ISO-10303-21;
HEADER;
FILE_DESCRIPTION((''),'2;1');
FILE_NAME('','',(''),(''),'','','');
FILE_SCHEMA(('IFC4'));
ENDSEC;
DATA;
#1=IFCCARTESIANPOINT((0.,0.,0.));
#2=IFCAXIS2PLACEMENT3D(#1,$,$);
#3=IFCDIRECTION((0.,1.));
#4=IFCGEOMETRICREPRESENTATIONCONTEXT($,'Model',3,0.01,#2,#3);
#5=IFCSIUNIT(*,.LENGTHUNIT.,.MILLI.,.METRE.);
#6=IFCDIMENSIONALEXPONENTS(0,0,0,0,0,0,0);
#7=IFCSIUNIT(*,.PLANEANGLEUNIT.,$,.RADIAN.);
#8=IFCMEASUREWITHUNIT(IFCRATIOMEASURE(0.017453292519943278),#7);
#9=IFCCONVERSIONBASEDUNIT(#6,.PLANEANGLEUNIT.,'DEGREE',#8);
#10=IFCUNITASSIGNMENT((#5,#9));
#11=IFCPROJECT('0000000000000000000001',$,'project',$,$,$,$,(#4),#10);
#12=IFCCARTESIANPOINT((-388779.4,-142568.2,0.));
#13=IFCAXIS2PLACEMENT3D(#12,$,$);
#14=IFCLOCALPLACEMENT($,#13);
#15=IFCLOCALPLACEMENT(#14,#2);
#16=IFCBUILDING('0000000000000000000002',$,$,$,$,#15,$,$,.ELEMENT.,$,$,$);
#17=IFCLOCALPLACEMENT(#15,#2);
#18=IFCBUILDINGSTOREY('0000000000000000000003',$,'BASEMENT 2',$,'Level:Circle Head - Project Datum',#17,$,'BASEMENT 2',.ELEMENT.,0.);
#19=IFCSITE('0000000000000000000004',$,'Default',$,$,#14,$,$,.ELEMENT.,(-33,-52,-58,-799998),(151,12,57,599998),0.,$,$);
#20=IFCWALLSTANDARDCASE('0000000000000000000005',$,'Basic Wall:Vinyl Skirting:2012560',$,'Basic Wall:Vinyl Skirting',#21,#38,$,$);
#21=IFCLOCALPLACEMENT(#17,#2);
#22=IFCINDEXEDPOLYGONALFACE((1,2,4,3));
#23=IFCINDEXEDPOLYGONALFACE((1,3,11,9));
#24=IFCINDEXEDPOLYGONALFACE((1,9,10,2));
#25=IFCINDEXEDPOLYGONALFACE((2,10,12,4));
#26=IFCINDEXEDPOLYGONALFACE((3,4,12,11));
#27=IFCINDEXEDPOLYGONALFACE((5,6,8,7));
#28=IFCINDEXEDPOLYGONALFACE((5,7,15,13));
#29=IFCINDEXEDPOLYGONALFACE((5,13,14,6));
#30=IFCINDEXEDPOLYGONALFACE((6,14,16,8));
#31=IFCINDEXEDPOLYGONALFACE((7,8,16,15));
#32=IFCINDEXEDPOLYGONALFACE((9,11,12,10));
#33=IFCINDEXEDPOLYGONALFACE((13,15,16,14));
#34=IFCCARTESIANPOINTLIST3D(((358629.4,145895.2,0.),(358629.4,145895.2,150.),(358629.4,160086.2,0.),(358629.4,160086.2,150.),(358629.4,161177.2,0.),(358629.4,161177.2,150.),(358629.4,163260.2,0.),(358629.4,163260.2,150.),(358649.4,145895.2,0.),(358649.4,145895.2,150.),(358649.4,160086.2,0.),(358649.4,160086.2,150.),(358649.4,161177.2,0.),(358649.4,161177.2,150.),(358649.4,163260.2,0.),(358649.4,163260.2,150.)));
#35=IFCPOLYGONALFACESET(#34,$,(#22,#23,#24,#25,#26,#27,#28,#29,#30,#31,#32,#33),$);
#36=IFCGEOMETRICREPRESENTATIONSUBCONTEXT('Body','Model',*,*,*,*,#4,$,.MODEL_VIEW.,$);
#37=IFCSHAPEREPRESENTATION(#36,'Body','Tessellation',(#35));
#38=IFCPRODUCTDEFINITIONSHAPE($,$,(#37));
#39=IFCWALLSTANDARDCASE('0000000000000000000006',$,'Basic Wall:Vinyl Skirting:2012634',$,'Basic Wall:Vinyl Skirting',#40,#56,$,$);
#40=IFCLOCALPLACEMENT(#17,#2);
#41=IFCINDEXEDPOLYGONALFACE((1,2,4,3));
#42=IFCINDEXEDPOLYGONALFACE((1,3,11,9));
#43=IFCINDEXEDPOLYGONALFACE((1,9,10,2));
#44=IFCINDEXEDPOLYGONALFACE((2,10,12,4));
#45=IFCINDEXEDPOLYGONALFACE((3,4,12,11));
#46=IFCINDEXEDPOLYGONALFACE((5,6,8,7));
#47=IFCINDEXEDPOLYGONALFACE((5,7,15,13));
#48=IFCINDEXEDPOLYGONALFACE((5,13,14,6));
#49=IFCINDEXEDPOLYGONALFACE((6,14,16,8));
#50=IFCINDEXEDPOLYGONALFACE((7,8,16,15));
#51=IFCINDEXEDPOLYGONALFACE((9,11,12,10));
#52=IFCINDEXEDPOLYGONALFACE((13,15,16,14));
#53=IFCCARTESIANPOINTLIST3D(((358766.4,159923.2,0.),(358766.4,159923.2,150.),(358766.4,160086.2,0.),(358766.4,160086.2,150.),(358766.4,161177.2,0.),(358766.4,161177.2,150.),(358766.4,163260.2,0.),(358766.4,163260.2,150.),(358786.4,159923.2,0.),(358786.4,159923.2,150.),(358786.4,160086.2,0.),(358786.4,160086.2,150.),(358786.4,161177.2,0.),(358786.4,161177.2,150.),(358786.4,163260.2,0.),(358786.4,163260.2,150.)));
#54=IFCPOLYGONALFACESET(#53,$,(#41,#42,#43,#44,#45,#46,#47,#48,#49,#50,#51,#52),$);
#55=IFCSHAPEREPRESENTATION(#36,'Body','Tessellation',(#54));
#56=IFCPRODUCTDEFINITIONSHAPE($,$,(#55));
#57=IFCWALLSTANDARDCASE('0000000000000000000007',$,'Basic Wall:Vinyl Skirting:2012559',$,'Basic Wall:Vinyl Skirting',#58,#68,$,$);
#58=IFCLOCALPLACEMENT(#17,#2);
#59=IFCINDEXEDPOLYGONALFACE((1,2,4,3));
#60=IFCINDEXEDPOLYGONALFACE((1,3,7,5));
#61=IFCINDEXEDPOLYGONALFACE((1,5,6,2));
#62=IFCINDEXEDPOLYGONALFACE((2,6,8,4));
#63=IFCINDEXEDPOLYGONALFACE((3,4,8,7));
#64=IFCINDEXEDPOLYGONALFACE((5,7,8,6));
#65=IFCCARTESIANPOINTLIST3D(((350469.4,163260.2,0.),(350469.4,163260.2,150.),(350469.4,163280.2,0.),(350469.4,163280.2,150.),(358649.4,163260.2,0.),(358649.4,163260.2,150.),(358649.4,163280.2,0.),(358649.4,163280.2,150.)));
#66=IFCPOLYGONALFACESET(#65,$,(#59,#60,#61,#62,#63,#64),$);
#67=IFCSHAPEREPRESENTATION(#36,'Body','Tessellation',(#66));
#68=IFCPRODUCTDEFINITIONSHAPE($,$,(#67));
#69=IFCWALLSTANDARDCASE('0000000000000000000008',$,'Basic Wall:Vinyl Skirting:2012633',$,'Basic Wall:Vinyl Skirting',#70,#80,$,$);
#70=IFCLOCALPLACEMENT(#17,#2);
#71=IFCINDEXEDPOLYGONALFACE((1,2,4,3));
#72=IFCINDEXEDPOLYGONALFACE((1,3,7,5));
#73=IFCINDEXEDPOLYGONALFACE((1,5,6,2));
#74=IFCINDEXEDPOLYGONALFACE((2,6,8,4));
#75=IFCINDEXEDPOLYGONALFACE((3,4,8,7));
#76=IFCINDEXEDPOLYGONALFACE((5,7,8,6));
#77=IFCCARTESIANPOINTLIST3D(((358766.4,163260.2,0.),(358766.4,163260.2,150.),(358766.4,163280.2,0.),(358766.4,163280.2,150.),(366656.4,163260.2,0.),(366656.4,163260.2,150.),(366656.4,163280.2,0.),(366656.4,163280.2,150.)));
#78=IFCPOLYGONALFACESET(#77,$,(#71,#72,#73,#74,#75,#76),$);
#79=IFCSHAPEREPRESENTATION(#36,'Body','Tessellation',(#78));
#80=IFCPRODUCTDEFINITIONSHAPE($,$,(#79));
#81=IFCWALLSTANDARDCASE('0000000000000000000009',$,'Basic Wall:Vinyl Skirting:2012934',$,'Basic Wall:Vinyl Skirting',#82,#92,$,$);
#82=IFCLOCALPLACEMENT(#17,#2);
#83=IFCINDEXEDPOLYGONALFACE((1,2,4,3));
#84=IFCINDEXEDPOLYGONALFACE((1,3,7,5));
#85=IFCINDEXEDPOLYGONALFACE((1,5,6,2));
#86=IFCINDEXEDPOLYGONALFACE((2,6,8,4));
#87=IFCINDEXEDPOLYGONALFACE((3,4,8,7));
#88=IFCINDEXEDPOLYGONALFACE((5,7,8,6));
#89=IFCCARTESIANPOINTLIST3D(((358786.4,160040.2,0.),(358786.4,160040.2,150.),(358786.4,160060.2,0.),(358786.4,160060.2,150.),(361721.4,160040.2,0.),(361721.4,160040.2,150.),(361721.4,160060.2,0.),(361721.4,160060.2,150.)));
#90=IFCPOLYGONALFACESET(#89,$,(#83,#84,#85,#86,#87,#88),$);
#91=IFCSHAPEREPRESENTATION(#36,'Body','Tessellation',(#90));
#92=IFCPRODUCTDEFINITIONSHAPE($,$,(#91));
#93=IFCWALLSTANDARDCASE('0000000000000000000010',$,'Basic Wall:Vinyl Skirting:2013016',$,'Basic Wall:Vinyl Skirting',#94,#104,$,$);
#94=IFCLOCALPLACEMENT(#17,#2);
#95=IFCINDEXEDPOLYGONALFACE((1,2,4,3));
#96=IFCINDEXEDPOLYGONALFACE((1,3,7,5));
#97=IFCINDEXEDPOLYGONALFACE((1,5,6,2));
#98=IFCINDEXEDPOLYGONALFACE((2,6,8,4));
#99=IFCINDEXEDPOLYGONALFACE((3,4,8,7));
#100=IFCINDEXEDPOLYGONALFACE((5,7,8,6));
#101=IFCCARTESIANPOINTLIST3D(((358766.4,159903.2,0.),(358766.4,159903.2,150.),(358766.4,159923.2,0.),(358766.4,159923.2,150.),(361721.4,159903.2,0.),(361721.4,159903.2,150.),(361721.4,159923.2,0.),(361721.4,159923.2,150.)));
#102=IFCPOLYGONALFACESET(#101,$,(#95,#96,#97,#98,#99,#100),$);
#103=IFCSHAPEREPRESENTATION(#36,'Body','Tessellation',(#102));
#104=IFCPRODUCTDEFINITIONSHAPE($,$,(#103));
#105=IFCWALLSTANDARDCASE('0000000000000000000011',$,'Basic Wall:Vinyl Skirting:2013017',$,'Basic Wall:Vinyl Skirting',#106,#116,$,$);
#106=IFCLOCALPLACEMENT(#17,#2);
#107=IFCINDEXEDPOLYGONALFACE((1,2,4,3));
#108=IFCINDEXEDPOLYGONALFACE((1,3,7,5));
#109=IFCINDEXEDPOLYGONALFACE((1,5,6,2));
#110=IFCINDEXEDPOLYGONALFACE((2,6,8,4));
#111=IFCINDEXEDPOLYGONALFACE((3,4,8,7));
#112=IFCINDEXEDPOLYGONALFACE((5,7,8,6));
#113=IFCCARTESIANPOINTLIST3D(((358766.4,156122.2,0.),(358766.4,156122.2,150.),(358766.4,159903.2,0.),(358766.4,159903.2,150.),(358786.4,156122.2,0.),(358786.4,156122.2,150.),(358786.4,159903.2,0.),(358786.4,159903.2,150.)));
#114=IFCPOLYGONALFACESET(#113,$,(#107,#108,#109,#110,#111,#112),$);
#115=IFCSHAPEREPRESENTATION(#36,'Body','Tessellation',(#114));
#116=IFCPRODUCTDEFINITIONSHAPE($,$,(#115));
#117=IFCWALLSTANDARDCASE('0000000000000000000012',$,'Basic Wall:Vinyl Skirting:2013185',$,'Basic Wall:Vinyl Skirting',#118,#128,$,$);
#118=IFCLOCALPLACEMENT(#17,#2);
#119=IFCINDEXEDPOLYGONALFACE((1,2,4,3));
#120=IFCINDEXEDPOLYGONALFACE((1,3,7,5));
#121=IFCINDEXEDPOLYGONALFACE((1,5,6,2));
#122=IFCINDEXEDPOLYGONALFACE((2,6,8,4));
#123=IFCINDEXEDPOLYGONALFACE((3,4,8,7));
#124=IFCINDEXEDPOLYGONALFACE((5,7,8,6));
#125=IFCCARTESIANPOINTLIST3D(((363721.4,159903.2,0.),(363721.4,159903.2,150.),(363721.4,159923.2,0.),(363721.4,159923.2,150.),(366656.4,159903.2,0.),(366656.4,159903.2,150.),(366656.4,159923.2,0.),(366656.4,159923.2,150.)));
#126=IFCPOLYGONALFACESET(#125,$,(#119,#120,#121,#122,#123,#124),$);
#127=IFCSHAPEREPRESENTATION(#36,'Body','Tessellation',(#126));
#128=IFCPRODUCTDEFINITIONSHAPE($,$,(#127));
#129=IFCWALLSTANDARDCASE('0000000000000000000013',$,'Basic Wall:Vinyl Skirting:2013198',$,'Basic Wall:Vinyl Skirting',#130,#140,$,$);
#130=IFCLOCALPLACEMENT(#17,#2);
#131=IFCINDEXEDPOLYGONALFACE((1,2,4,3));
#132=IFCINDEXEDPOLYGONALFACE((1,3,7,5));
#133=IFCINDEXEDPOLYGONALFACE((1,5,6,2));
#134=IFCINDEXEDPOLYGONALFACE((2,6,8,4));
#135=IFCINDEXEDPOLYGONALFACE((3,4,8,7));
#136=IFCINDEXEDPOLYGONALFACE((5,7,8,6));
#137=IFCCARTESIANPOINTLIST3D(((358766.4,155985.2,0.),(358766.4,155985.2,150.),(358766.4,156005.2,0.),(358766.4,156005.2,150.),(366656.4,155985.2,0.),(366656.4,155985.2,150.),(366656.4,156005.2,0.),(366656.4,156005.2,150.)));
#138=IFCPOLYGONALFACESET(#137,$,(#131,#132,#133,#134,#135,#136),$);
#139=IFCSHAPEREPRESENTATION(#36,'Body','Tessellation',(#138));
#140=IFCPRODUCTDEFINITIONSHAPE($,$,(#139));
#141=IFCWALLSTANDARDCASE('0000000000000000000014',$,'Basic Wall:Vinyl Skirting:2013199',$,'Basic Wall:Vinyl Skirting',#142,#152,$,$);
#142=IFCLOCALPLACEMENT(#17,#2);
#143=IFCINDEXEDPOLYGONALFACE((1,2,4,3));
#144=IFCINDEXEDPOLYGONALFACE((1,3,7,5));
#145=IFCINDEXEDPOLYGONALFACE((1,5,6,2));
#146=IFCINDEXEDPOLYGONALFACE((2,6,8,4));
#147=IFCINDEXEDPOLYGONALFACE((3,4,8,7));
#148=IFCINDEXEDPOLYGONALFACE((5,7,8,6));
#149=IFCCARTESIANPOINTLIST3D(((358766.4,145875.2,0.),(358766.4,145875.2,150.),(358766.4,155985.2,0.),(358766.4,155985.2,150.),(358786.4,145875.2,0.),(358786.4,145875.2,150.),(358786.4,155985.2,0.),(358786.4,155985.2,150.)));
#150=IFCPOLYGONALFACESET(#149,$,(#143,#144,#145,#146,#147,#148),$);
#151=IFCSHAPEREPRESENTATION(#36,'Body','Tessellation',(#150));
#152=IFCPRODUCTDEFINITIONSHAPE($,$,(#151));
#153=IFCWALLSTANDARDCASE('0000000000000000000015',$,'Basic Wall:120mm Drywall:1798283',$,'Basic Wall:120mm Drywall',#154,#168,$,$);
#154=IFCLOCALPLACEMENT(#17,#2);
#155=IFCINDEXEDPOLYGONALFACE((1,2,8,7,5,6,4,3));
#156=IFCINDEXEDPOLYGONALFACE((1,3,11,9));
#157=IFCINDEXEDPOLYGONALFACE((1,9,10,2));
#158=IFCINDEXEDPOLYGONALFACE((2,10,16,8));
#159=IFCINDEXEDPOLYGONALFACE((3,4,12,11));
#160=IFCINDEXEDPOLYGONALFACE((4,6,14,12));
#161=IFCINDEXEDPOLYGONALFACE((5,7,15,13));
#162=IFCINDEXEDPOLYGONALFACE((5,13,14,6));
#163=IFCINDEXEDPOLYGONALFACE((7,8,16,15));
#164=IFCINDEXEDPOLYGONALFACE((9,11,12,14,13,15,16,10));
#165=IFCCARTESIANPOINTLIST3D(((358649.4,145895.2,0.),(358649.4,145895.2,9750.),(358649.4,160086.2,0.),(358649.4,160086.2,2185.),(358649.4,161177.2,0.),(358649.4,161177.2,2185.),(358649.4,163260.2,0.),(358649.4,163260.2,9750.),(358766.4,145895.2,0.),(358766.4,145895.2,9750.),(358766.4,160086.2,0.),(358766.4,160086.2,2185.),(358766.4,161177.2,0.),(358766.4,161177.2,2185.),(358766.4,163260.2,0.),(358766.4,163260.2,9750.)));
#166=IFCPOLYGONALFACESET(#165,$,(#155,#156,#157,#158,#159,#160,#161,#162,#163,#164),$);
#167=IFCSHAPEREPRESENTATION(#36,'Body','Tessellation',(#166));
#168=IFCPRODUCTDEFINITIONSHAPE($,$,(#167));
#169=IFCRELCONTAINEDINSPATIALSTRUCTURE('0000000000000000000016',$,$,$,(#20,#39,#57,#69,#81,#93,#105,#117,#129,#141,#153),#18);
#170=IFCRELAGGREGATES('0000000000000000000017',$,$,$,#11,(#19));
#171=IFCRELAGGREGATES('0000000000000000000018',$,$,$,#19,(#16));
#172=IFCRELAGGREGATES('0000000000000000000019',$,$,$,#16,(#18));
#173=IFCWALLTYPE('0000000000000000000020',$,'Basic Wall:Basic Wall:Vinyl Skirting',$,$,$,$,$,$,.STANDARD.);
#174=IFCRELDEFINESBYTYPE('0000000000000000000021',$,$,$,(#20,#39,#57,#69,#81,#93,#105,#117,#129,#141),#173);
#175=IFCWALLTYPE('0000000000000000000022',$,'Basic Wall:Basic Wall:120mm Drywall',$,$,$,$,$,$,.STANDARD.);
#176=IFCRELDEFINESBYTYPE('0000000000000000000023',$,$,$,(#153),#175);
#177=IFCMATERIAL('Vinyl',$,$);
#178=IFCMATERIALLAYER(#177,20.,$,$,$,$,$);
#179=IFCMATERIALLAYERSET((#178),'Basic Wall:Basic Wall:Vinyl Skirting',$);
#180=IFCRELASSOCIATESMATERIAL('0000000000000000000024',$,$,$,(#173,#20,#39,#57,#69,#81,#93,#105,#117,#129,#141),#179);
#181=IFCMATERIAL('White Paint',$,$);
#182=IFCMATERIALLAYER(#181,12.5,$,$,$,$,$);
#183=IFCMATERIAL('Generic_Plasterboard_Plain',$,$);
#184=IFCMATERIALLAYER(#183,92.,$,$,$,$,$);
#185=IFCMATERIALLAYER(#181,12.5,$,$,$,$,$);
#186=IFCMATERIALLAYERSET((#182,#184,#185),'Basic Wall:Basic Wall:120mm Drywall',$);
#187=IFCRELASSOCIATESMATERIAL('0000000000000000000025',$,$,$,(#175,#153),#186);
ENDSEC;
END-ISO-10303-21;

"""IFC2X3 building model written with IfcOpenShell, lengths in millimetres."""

from ifc_helpers import new_model, entity, si_unit, converted_unit, direction, frame, frame_2d, origin, origin_2d_with_axis, place, context, subcontext, project, spatial, rectangle, extrude, material, layer, layer_set, layer_usage, type_object, element, save


model = new_model("IFC2X3")

# Units and contexts
model_context = context("Model", 3, precision=0.01, world=origin(), true_north=direction((0.0, 1.0)))
body_context = subcontext(model_context, "Body", "Model", "MODEL_VIEW")
ifc_project = project(units=[si_unit("LENGTHUNIT", "METRE", prefix="MILLI"), converted_unit("PLANEANGLEUNIT", "DEGREE", entity("IfcRatioMeasure", 0.017453292519943278), si_unit("PLANEANGLEUNIT", "RADIAN"), dimensions=[0, 0, 0, 0, 0, 0, 0])], contexts=[model_context])

# Site, building, storey
site_placement = place(None, frame((-388779.4, -142568.2, 0.0)))
site = spatial("IfcSite", under=ifc_project, at=site_placement, Name="Default", CompositionType="ELEMENT", RefLatitude=(-33, -52, -58, -799998), RefLongitude=(151, 12, 57, 599998), RefElevation=0.0)
building_placement = place(site_placement, origin())
building = spatial("IfcBuilding", under=site, at=building_placement, CompositionType="ELEMENT")
storey_placement = place(building_placement, origin())
storey = spatial("IfcBuildingStorey", under=building, at=storey_placement, Name="BASEMENT 2", ObjectType="Level:Circle Head - Project Datum", LongName="BASEMENT 2", CompositionType="ELEMENT", Elevation=0.0)

# Walls, openings
ifc_material_1 = material(Name="Vinyl")
ifc_layer_1 = layer(ifc_material_1, 20.0)
ifc_layer_set_1 = layer_set([ifc_layer_1], Name="Basic Wall:Basic Wall:Vinyl Skirting")
ifc_layer_usage_1 = layer_usage(ifc_layer_set_1, "AXIS2", "NEGATIVE", 10.0)
wall_type_1 = type_object("IfcWallType", Name="Basic Wall:Basic Wall:Vinyl Skirting", PredefinedType="STANDARD", material=ifc_layer_set_1)
wall_1_placement = place(storey_placement, frame((358639.4, 145895.2, 0.0), z_axis=(0.0, 0.0, 1.0), x_axis=(0.0, 1.0, 0.0)))
wall_1 = element("IfcWallStandardCase", 1, at=wall_1_placement, inside=storey, type_object=wall_type_1, material=ifc_layer_usage_1, Name="Basic Wall:Vinyl Skirting:2012560", ObjectType="Basic Wall:Vinyl Skirting", context=body_context, shape_type="SweptSolid", body=[
    extrude(rectangle(XDim=20.0, YDim=17365.0, at=frame_2d((8682.5, 0.0), x_axis=(0.0, -1.0))), origin(), (0.0, 0.0, 1.0), 150.0),
])
opening_1_placement = place(wall_1_placement, origin())
element("IfcOpeningElement", 2, at=opening_1_placement, cuts=wall_1, ObjectType="Opening", context=body_context, shape_type="SweptSolid", body=[
    extrude(rectangle(XDim=2185.0, YDim=1091.0, at=origin_2d_with_axis()), frame((14736.5, -10.0, 1092.5), z_axis=(0.0, 1.0, 0.0), x_axis=(0.0, 0.0, -1.0)), (0.0, 0.0, 1.0), 20.0),
])
ifc_layer_usage_2 = layer_usage(ifc_layer_set_1, "AXIS2", "NEGATIVE", 10.0)
wall_2_placement = place(storey_placement, frame((358776.4, 159923.2, 0.0), z_axis=(0.0, 0.0, 1.0), x_axis=(0.0, 1.0, 0.0)))
wall_2 = element("IfcWallStandardCase", 3, at=wall_2_placement, inside=storey, type_object=wall_type_1, material=ifc_layer_usage_2, Name="Basic Wall:Vinyl Skirting:2012634", ObjectType="Basic Wall:Vinyl Skirting", context=body_context, shape_type="SweptSolid", body=[
    extrude(rectangle(XDim=20.0, YDim=3337.0, at=frame_2d((1668.5, 0.0), x_axis=(0.0, -1.0))), origin(), (0.0, 0.0, 1.0), 150.0),
])
opening_2_placement = place(wall_2_placement, origin())
element("IfcOpeningElement", 4, at=opening_2_placement, cuts=wall_2, ObjectType="Opening", context=body_context, shape_type="SweptSolid", body=[
    extrude(rectangle(XDim=2185.0, YDim=1091.0, at=origin_2d_with_axis()), frame((708.5, -10.0, 1092.5), z_axis=(0.0, 1.0, 0.0), x_axis=(0.0, 0.0, -1.0)), (0.0, 0.0, 1.0), 20.0),
])

# Walls
ifc_layer_usage_3 = layer_usage(ifc_layer_set_1, "AXIS2", "NEGATIVE", 10.0)
wall_3_placement = place(storey_placement, frame((358649.4, 163270.2, 0.0), z_axis=(0.0, 0.0, 1.0), x_axis=(-1.0, 0.0, 0.0)))
element("IfcWallStandardCase", 5, at=wall_3_placement, inside=storey, type_object=wall_type_1, material=ifc_layer_usage_3, Name="Basic Wall:Vinyl Skirting:2012559", ObjectType="Basic Wall:Vinyl Skirting", context=body_context, shape_type="SweptSolid", body=[
    extrude(rectangle(XDim=8180.0, YDim=20.0, at=frame_2d((4090.0, 0.0), x_axis=(-1.0, 0.0))), origin(), (0.0, 0.0, 1.0), 150.0),
])
ifc_layer_usage_4 = layer_usage(ifc_layer_set_1, "AXIS2", "NEGATIVE", 10.0)
wall_4_placement = place(storey_placement, frame((358766.4, 163270.2, 0.0)))
element("IfcWallStandardCase", 6, at=wall_4_placement, inside=storey, type_object=wall_type_1, material=ifc_layer_usage_4, Name="Basic Wall:Vinyl Skirting:2012633", ObjectType="Basic Wall:Vinyl Skirting", context=body_context, shape_type="SweptSolid", body=[
    extrude(rectangle(XDim=7890.0, YDim=20.0, at=frame_2d((3945.0, 0.0), x_axis=(-1.0, 0.0))), origin(), (0.0, 0.0, 1.0), 150.0),
])
ifc_layer_usage_5 = layer_usage(ifc_layer_set_1, "AXIS2", "NEGATIVE", 10.0)
wall_5_placement = place(storey_placement, frame((361721.4, 160050.2, 0.0), z_axis=(0.0, 0.0, 1.0), x_axis=(-1.0, 0.0, 0.0)))
element("IfcWallStandardCase", 7, at=wall_5_placement, inside=storey, type_object=wall_type_1, material=ifc_layer_usage_5, Name="Basic Wall:Vinyl Skirting:2012934", ObjectType="Basic Wall:Vinyl Skirting", context=body_context, shape_type="SweptSolid", body=[
    extrude(rectangle(XDim=2935.0, YDim=20.0, at=frame_2d((1467.5, 0.0), x_axis=(-1.0, 0.0))), origin(), (0.0, 0.0, 1.0), 150.0),
])
ifc_layer_usage_6 = layer_usage(ifc_layer_set_1, "AXIS2", "NEGATIVE", 10.0)
wall_6_placement = place(storey_placement, frame((358766.4, 159913.2, 0.0)))
element("IfcWallStandardCase", 8, at=wall_6_placement, inside=storey, type_object=wall_type_1, material=ifc_layer_usage_6, Name="Basic Wall:Vinyl Skirting:2013016", ObjectType="Basic Wall:Vinyl Skirting", context=body_context, shape_type="SweptSolid", body=[
    extrude(rectangle(XDim=2955.0, YDim=20.0, at=frame_2d((1477.5, 0.0), x_axis=(-1.0, 0.0))), origin(), (0.0, 0.0, 1.0), 150.0),
])
ifc_layer_usage_7 = layer_usage(ifc_layer_set_1, "AXIS2", "NEGATIVE", 10.0)
wall_7_placement = place(storey_placement, frame((358776.4, 156122.2, 0.0), z_axis=(0.0, 0.0, 1.0), x_axis=(0.0, 1.0, 0.0)))
element("IfcWallStandardCase", 9, at=wall_7_placement, inside=storey, type_object=wall_type_1, material=ifc_layer_usage_7, Name="Basic Wall:Vinyl Skirting:2013017", ObjectType="Basic Wall:Vinyl Skirting", context=body_context, shape_type="SweptSolid", body=[
    extrude(rectangle(XDim=3781.0, YDim=20.0, at=frame_2d((1890.5, 0.0), x_axis=(-1.0, 0.0))), origin(), (0.0, 0.0, 1.0), 150.0),
])
ifc_layer_usage_8 = layer_usage(ifc_layer_set_1, "AXIS2", "NEGATIVE", 10.0)
wall_8_placement = place(storey_placement, frame((363721.4, 159913.2, 0.0)))
element("IfcWallStandardCase", 10, at=wall_8_placement, inside=storey, type_object=wall_type_1, material=ifc_layer_usage_8, Name="Basic Wall:Vinyl Skirting:2013185", ObjectType="Basic Wall:Vinyl Skirting", context=body_context, shape_type="SweptSolid", body=[
    extrude(rectangle(XDim=2935.0, YDim=20.0, at=frame_2d((1467.5, 0.0), x_axis=(-1.0, 0.0))), origin(), (0.0, 0.0, 1.0), 150.0),
])
ifc_layer_usage_9 = layer_usage(ifc_layer_set_1, "AXIS2", "NEGATIVE", 10.0)
wall_9_placement = place(storey_placement, frame((358766.4, 155995.2, 0.0)))
element("IfcWallStandardCase", 11, at=wall_9_placement, inside=storey, type_object=wall_type_1, material=ifc_layer_usage_9, Name="Basic Wall:Vinyl Skirting:2013198", ObjectType="Basic Wall:Vinyl Skirting", context=body_context, shape_type="SweptSolid", body=[
    extrude(rectangle(XDim=7890.0, YDim=20.0, at=frame_2d((3945.0, 0.0), x_axis=(-1.0, 0.0))), origin(), (0.0, 0.0, 1.0), 150.0),
])
ifc_layer_usage_10 = layer_usage(ifc_layer_set_1, "AXIS2", "NEGATIVE", 10.0)
wall_10_placement = place(storey_placement, frame((358776.4, 145875.2, 0.0), z_axis=(0.0, 0.0, 1.0), x_axis=(0.0, 1.0, 0.0)))
element("IfcWallStandardCase", 12, at=wall_10_placement, inside=storey, type_object=wall_type_1, material=ifc_layer_usage_10, Name="Basic Wall:Vinyl Skirting:2013199", ObjectType="Basic Wall:Vinyl Skirting", context=body_context, shape_type="SweptSolid", body=[
    extrude(rectangle(XDim=10110.0, YDim=20.0, at=frame_2d((5055.0, 0.0), x_axis=(-1.0, 0.0))), origin(), (0.0, 0.0, 1.0), 150.0),
])

# Wall, opening
ifc_material_2 = material(Name="White Paint")
ifc_layer_2 = layer(ifc_material_2, 12.5)
ifc_material_3 = material(Name="Generic_Plasterboard_Plain")
ifc_layer_3 = layer(ifc_material_3, 92.0)
ifc_layer_4 = layer(ifc_material_2, 12.5)
ifc_layer_set_2 = layer_set([ifc_layer_2, ifc_layer_3, ifc_layer_4], Name="Basic Wall:Basic Wall:120mm Drywall")
ifc_layer_usage_11 = layer_usage(ifc_layer_set_2, "AXIS2", "NEGATIVE", 58.5)
wall_type_2 = type_object("IfcWallType", Name="Basic Wall:Basic Wall:120mm Drywall", PredefinedType="STANDARD", material=ifc_layer_set_2)
wall_11_placement = place(storey_placement, frame((358707.9, 145895.2, 0.0), z_axis=(0.0, 0.0, 1.0), x_axis=(0.0, 1.0, 0.0)))
wall_11 = element("IfcWallStandardCase", 13, at=wall_11_placement, inside=storey, type_object=wall_type_2, material=ifc_layer_usage_11, Name="Basic Wall:120mm Drywall:1798283", ObjectType="Basic Wall:120mm Drywall", context=body_context, shape_type="SweptSolid", body=[
    extrude(rectangle(XDim=17365.0, YDim=117.0, at=frame_2d((8682.5, 0.0), x_axis=(1.0, 0.0))), origin(), (0.0, 0.0, 1.0), 9750.0),
])
opening_3_placement = place(wall_11_placement, frame((-145895.2, 358707.9, 0.0), z_axis=(0.0, 0.0, 1.0), x_axis=(0.0, -1.0, 0.0)))
element("IfcOpeningElement", 14, at=opening_3_placement, cuts=wall_11, ObjectType="Opening", context=body_context, shape_type="SweptSolid", body=[
    extrude(rectangle(XDim=2185.0, YDim=1091.0, at=frame_2d((0.0, 0.0), x_axis=(0.0, 1.0))), frame((358767.6, 160631.7, 1092.5), z_axis=(-1.0, 0.0, 0.0), x_axis=(0.0, 1.0, 0.0)), (0.0, 0.0, 1.0), 119.3),
])

save(model, "model.ifc")
